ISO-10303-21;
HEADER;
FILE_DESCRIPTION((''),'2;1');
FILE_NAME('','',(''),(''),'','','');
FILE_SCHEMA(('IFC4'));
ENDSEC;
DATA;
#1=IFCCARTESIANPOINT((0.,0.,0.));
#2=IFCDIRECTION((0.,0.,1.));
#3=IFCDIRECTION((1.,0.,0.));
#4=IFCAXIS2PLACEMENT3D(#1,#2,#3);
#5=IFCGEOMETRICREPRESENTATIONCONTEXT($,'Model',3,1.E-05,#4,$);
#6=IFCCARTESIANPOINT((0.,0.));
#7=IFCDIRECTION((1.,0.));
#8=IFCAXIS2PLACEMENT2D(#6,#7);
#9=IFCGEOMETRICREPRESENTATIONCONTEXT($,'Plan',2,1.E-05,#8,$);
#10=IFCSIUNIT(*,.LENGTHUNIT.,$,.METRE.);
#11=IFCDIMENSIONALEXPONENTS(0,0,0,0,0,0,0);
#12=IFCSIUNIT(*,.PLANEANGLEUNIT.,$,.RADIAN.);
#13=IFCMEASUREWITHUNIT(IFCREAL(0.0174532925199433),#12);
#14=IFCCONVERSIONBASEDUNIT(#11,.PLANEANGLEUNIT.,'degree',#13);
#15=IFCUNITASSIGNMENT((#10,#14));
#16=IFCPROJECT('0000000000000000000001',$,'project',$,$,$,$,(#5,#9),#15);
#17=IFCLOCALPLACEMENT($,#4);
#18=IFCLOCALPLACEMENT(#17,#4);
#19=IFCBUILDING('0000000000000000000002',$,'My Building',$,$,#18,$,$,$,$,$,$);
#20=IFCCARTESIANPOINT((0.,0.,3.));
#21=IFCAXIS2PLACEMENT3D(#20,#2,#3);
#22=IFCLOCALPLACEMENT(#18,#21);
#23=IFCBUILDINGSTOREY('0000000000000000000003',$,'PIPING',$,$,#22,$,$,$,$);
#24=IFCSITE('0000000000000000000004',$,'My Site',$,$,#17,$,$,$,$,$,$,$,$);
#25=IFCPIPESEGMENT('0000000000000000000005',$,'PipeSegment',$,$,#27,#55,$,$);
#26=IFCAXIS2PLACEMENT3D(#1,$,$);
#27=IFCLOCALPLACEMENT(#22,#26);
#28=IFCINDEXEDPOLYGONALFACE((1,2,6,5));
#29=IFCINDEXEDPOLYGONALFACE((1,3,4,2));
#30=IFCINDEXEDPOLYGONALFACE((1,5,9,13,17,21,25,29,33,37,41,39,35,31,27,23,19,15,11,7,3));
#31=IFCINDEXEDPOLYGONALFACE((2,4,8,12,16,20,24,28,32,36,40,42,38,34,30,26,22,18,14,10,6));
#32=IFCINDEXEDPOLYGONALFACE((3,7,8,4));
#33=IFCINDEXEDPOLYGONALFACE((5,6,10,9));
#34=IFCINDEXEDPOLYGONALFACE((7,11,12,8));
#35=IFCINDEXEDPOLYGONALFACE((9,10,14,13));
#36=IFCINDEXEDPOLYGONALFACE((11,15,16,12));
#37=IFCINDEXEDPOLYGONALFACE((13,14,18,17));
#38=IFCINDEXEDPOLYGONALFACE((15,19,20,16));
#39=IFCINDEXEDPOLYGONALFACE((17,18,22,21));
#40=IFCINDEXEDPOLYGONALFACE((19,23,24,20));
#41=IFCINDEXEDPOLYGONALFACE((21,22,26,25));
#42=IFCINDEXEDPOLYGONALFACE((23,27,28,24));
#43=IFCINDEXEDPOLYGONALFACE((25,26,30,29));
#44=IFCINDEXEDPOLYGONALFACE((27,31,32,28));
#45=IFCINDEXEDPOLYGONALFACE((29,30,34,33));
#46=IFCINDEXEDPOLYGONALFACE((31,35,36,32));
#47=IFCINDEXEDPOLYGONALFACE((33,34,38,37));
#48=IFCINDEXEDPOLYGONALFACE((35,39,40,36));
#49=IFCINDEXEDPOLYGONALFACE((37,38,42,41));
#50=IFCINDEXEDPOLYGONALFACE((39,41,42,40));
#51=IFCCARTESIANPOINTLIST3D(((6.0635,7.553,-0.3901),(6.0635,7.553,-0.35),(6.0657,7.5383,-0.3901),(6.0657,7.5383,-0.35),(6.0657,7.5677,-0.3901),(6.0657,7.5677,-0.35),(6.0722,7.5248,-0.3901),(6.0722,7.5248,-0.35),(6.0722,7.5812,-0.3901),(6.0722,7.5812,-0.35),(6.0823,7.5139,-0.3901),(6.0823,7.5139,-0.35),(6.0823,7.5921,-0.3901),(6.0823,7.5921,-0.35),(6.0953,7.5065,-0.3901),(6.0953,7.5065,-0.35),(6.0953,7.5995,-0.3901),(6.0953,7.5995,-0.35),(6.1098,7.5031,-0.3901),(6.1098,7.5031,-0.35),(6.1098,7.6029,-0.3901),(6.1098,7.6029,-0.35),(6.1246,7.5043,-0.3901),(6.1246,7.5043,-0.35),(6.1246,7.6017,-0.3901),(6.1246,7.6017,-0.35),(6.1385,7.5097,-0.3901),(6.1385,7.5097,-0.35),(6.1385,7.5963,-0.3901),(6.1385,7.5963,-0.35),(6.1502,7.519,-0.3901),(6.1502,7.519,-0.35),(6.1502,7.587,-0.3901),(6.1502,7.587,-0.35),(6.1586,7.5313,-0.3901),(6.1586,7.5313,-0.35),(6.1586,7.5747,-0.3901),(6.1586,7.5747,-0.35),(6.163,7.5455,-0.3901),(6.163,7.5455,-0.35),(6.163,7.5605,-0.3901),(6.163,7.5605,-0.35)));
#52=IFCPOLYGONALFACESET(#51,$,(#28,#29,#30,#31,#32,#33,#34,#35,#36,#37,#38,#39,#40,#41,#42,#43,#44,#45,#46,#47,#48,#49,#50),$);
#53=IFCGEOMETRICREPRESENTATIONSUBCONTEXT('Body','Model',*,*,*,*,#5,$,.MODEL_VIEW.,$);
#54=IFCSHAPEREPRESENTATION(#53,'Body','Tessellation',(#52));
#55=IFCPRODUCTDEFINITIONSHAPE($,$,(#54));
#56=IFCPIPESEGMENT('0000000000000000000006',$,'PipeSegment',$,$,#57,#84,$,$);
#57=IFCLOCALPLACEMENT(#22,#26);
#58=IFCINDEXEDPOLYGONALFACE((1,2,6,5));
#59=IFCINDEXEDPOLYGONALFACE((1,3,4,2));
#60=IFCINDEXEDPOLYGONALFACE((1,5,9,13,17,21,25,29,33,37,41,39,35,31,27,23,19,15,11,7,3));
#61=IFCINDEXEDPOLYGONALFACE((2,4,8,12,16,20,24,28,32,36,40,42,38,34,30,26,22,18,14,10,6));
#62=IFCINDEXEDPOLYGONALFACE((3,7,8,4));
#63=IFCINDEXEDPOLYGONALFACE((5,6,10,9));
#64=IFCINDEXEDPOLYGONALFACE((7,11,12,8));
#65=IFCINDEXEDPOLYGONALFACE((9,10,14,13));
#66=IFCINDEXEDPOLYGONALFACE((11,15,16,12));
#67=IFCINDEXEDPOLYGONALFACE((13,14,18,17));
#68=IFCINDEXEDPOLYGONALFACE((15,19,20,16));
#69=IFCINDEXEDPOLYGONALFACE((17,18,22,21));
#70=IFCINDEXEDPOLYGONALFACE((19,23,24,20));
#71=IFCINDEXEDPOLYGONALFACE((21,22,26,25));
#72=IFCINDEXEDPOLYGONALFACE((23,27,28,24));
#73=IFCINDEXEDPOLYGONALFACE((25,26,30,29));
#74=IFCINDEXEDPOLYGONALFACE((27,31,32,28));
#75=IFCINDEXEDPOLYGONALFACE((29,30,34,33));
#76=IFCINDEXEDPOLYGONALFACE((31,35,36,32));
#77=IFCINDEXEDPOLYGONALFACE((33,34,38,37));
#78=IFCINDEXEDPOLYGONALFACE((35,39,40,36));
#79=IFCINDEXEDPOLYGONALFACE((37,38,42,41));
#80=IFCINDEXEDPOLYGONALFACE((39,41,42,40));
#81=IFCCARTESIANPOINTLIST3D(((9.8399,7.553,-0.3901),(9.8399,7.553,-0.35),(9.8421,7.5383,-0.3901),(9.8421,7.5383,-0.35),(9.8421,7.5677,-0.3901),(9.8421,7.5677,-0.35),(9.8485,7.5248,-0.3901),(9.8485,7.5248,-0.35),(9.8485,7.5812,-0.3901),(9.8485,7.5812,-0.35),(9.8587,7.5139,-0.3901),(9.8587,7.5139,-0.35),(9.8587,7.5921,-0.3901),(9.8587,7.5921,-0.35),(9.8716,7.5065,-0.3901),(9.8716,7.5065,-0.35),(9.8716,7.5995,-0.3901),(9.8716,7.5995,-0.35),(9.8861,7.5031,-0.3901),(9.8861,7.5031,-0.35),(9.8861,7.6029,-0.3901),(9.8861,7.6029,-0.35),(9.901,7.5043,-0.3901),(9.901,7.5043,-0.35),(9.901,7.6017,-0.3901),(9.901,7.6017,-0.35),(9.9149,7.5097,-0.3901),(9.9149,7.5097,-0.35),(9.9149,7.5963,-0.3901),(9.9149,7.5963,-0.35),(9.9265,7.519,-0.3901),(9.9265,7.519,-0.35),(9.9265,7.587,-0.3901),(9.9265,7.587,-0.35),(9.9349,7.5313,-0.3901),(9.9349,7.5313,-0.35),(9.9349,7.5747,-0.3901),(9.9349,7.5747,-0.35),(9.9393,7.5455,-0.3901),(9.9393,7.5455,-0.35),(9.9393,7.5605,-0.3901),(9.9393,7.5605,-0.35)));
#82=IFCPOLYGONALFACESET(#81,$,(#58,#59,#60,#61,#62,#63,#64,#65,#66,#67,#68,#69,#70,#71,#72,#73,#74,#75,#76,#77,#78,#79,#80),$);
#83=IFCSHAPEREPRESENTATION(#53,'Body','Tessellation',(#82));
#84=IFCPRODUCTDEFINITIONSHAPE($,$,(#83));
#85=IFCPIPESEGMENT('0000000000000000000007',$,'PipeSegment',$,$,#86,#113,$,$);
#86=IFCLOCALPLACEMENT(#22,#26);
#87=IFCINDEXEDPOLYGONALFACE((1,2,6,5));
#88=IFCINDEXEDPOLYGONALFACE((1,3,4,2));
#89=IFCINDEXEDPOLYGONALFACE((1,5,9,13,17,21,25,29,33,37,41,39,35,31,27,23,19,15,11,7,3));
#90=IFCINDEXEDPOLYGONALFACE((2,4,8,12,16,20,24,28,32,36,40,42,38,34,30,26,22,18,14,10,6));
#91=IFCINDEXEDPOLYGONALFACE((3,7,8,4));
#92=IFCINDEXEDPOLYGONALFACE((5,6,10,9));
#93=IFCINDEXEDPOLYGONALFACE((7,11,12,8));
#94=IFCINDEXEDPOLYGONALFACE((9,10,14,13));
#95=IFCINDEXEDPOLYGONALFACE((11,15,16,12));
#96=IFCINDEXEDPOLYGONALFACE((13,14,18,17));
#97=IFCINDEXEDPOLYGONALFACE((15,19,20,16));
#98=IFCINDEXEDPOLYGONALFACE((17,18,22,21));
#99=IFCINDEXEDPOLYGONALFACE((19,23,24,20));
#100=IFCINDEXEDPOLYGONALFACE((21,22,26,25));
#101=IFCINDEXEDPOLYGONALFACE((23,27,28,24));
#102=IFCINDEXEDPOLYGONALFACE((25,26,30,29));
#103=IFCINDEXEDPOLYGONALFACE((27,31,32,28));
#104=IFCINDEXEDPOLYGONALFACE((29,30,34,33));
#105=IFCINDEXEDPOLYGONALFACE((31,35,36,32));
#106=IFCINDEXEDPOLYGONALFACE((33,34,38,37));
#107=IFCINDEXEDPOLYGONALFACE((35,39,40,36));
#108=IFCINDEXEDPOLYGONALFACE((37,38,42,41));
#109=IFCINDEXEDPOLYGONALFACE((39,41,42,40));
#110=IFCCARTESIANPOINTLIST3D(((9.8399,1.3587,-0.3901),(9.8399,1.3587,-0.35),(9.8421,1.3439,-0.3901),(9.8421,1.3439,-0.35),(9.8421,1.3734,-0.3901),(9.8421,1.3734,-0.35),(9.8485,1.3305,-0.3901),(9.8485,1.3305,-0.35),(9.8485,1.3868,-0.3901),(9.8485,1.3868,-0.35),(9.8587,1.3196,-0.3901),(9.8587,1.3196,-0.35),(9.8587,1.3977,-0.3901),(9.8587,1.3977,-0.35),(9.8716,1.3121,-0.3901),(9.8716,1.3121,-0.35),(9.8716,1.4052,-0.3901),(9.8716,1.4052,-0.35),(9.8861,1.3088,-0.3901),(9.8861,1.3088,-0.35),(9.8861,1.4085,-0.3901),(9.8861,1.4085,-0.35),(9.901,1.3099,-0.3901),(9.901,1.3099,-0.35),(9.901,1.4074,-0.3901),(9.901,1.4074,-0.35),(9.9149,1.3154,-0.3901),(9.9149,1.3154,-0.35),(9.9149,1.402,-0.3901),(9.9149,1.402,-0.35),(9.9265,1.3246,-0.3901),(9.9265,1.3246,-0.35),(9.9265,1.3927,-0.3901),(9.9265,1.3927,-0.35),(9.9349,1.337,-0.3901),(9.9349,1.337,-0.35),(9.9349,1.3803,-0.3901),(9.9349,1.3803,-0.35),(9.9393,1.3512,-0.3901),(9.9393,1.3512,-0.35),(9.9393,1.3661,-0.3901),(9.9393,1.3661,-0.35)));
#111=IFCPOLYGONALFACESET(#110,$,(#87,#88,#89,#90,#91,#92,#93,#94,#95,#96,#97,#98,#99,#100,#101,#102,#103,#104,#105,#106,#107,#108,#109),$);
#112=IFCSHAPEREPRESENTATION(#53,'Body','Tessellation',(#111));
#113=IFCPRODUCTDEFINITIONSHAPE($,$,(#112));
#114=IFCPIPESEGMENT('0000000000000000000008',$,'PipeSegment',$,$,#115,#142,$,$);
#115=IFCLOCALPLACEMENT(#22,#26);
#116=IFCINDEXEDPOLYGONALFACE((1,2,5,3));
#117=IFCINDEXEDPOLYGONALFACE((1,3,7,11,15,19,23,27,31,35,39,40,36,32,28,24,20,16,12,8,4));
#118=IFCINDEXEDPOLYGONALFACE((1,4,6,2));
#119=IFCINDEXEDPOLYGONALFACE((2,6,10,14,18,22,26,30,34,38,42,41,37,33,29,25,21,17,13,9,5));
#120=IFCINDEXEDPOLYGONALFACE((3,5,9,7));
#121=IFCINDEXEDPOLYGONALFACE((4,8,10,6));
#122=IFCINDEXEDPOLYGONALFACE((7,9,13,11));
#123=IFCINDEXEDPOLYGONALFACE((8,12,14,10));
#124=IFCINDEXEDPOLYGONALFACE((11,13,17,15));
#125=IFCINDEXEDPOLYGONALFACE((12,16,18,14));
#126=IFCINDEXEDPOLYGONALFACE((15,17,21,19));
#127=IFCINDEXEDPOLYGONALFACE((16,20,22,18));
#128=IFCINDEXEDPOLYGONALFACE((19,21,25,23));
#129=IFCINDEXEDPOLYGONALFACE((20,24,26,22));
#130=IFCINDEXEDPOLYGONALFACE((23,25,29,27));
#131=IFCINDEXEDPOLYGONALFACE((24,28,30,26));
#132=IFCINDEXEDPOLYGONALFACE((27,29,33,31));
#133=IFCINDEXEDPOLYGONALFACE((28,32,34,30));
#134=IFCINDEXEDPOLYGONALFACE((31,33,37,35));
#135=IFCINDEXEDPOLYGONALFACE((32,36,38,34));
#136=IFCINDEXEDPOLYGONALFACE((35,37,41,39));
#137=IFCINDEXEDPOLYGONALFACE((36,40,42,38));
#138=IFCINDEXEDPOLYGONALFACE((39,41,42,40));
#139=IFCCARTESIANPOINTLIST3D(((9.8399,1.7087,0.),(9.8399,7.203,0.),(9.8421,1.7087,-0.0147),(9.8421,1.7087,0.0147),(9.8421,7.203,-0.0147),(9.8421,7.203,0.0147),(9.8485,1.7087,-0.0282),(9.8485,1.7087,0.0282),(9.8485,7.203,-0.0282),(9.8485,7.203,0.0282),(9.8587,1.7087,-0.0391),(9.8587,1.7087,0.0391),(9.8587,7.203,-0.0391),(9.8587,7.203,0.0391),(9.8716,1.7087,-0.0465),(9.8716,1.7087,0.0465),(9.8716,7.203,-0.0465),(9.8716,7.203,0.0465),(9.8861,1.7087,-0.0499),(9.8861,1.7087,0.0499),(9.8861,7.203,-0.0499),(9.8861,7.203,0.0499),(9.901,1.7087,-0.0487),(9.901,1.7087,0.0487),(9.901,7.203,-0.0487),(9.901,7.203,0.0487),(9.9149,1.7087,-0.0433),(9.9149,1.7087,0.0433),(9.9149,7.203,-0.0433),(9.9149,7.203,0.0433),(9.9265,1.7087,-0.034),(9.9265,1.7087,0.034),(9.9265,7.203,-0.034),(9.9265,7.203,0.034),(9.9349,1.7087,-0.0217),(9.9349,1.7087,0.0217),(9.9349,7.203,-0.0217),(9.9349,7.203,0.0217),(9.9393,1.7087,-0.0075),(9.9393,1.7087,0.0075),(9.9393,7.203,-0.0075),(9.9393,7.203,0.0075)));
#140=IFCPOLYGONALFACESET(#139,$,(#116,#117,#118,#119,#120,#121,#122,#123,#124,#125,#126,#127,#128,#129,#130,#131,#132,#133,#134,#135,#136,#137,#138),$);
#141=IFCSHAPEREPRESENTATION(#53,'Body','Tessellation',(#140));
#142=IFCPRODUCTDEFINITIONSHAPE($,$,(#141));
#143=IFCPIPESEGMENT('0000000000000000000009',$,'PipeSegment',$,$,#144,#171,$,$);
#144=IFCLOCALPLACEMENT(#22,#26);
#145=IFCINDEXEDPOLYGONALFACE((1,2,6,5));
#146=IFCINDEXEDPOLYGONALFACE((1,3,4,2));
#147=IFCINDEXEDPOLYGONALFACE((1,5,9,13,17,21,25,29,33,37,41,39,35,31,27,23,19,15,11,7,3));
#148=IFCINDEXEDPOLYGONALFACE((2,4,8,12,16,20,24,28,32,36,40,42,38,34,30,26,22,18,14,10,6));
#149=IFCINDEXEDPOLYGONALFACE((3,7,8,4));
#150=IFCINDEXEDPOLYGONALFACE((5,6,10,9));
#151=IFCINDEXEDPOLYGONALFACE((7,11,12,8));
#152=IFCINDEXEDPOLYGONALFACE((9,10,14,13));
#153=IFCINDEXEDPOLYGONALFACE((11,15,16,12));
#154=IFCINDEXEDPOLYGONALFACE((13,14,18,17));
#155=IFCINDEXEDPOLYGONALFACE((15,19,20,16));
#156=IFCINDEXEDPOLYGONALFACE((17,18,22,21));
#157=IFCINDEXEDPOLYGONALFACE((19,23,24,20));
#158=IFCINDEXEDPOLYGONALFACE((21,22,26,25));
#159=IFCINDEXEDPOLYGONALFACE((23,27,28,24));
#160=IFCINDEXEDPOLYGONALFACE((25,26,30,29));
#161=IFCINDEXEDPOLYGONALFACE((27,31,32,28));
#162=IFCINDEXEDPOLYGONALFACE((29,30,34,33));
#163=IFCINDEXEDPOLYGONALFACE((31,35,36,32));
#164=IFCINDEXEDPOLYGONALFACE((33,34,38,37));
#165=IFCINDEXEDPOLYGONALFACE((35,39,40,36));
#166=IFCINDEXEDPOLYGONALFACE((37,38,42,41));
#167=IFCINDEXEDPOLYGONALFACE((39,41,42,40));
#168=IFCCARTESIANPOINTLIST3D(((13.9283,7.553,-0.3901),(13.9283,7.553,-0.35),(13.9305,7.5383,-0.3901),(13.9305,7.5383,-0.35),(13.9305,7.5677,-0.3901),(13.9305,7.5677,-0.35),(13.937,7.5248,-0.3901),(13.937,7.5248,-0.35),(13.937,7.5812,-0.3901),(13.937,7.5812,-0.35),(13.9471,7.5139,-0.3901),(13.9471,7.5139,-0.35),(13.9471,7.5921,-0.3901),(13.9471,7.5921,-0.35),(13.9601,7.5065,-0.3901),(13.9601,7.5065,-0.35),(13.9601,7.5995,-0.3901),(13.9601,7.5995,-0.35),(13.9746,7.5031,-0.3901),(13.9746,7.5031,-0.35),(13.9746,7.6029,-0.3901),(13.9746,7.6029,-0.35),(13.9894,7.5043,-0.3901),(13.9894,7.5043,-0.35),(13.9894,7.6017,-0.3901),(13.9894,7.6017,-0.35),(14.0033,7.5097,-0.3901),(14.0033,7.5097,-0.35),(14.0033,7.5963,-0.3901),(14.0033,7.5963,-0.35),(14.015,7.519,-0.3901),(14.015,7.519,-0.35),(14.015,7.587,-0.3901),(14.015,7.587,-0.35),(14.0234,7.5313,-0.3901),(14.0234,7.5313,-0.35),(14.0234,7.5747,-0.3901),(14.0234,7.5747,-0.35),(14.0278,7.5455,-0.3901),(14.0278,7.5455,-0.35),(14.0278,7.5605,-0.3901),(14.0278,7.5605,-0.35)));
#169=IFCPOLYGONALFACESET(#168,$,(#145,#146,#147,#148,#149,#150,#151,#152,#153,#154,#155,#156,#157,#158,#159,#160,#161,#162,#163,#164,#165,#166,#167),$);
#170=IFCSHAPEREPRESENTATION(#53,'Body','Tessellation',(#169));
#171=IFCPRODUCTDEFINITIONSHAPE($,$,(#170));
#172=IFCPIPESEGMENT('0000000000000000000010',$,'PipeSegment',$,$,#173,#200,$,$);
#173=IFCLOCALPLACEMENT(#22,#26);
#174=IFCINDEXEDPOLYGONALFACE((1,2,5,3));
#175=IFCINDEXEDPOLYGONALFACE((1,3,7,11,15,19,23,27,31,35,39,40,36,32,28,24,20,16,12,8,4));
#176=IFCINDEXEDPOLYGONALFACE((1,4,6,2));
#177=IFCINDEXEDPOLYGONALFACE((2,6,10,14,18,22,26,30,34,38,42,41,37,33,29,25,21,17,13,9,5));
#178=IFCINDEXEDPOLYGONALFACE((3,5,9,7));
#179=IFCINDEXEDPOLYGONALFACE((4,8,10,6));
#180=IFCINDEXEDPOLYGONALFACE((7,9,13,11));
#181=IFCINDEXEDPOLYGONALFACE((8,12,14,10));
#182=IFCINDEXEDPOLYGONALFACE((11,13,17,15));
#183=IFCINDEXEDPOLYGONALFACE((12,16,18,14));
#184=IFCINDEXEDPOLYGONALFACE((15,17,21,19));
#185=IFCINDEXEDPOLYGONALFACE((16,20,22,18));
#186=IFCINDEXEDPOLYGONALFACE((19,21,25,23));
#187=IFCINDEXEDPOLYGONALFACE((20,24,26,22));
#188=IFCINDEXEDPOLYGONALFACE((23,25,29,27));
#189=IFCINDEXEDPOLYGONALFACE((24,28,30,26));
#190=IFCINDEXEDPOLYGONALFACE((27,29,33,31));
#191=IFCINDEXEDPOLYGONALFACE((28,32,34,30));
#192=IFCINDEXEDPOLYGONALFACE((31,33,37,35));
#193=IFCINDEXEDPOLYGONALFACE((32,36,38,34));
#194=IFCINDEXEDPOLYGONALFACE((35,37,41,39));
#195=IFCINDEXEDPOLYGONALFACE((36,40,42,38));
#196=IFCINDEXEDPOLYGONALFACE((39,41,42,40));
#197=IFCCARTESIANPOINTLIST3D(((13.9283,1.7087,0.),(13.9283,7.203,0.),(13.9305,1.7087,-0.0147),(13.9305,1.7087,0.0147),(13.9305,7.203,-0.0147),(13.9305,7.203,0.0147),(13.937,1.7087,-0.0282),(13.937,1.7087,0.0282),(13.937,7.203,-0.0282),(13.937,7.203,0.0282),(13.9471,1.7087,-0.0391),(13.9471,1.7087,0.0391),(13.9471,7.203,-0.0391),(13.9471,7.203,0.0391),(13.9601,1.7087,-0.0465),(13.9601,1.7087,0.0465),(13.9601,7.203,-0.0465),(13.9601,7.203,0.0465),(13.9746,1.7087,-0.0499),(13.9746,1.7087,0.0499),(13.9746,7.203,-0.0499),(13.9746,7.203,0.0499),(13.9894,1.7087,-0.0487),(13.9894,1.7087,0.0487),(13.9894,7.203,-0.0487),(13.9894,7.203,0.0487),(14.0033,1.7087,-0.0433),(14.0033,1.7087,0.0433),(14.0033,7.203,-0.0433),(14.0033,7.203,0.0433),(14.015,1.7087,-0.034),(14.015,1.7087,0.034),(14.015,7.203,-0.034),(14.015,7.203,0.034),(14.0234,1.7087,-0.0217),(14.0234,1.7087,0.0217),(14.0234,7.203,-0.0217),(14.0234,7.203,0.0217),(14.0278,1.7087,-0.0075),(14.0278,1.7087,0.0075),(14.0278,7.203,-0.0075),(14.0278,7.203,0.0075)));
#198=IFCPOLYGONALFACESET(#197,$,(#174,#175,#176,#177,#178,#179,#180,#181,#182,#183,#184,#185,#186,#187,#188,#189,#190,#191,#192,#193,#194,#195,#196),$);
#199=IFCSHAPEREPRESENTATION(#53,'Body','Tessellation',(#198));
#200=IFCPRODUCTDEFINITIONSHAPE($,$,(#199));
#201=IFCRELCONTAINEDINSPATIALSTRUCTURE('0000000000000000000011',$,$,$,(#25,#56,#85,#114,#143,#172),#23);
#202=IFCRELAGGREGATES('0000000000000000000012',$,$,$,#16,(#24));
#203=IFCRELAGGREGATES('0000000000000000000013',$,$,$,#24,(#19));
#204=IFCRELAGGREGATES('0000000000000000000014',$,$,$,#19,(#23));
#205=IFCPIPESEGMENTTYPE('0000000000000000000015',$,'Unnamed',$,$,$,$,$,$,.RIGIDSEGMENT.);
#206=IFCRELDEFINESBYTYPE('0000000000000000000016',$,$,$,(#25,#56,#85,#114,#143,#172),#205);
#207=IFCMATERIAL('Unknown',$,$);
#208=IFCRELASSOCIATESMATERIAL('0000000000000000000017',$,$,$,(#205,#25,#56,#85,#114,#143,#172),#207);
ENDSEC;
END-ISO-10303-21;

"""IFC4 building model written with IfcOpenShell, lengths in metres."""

from ifc_helpers import new_model, entity, si_unit, converted_unit, frame, origin_with_axes, origin_2d_with_axis, place, context, subcontext, project, spatial, circle, extrude, material, material_profile, profile_set, profile_usage, type_object, element, save


model = new_model("IFC4")

# Units and contexts
model_context = context("Model", 3, precision=1e-05, world=origin_with_axes())
plan_context = context("Plan", 2, precision=1e-05, world=origin_2d_with_axis())
body_context = subcontext(model_context, "Body", "Model", "MODEL_VIEW")
ifc_project = project(units=[si_unit("LENGTHUNIT", "METRE"), converted_unit("PLANEANGLEUNIT", "degree", entity("IfcReal", 0.0174532925199433), si_unit("PLANEANGLEUNIT", "RADIAN"), dimensions=[0, 0, 0, 0, 0, 0, 0])], contexts=[model_context, plan_context])

# Site, building, storey
site_placement = place(None, origin_with_axes())
site = spatial("IfcSite", under=ifc_project, at=site_placement, Name="My Site")
building_placement = place(site_placement, origin_with_axes())
building = spatial("IfcBuilding", under=site, at=building_placement, Name="My Building")
storey_placement = place(building_placement, frame((0.0, 0.0, 3.0), z_axis=(0.0, 0.0, 1.0), x_axis=(1.0, 0.0, 0.0)))
storey = spatial("IfcBuildingStorey", under=building, at=storey_placement, Name="PIPING")

# Pipe segments
ifc_material = material(Name="Unknown")
ifc_material_profile = material_profile(ifc_material, circle(Radius=0.05))
ifc_profile_set = profile_set([ifc_material_profile])
pipe_segment_type = type_object("IfcPipeSegmentType", Name="Unnamed", PredefinedType="RIGIDSEGMENT", material=ifc_profile_set)
ifc_profile_usage_1 = profile_usage(ifc_profile_set, cardinal=5)
pipe_segment_1_placement = place(storey_placement, frame((6.1135, 7.553, -0.35), z_axis=(0.0, 0.0, -1.0), x_axis=(-1.0, 0.0, 0.0)))
element("IfcPipeSegment", 1, at=pipe_segment_1_placement, inside=storey, type_object=pipe_segment_type, material=ifc_profile_usage_1, Name="PipeSegment", context=body_context, shape_type="SweptSolid", body=[
    extrude(circle(Radius=0.05), origin_with_axes(), (0.0, 0.0, 1.0), 0.0401),
])
ifc_profile_usage_2 = profile_usage(ifc_profile_set, cardinal=5)
pipe_segment_2_placement = place(storey_placement, frame((9.8899, 7.553, -0.35), z_axis=(0.0, 0.0, -1.0), x_axis=(-1.0, 0.0, 0.0)))
element("IfcPipeSegment", 2, at=pipe_segment_2_placement, inside=storey, type_object=pipe_segment_type, material=ifc_profile_usage_2, Name="PipeSegment", context=body_context, shape_type="SweptSolid", body=[
    extrude(circle(Radius=0.05), origin_with_axes(), (0.0, 0.0, 1.0), 0.0401),
])
ifc_profile_usage_3 = profile_usage(ifc_profile_set, cardinal=5)
pipe_segment_3_placement = place(storey_placement, frame((9.8899, 1.3587, -0.35), z_axis=(0.0, 0.0, -1.0), x_axis=(-1.0, 0.0, 0.0)))
element("IfcPipeSegment", 3, at=pipe_segment_3_placement, inside=storey, type_object=pipe_segment_type, material=ifc_profile_usage_3, Name="PipeSegment", context=body_context, shape_type="SweptSolid", body=[
    extrude(circle(Radius=0.05), origin_with_axes(), (0.0, 0.0, 1.0), 0.0401),
])
ifc_profile_usage_4 = profile_usage(ifc_profile_set, cardinal=5)
pipe_segment_4_placement = place(storey_placement, frame((9.8899, 1.7087, 0.0), z_axis=(0.0, 1.0, 0.0), x_axis=(-1.0, 0.0, 0.0)))
element("IfcPipeSegment", 4, at=pipe_segment_4_placement, inside=storey, type_object=pipe_segment_type, material=ifc_profile_usage_4, Name="PipeSegment", context=body_context, shape_type="SweptSolid", body=[
    extrude(circle(Radius=0.05), origin_with_axes(), (0.0, 0.0, 1.0), 5.4943),
])
ifc_profile_usage_5 = profile_usage(ifc_profile_set, cardinal=5)
pipe_segment_5_placement = place(storey_placement, frame((13.9783, 7.553, -0.35), z_axis=(0.0, 0.0, -1.0), x_axis=(-1.0, 0.0, 0.0)))
element("IfcPipeSegment", 5, at=pipe_segment_5_placement, inside=storey, type_object=pipe_segment_type, material=ifc_profile_usage_5, Name="PipeSegment", context=body_context, shape_type="SweptSolid", body=[
    extrude(circle(Radius=0.05), origin_with_axes(), (0.0, 0.0, 1.0), 0.0401),
])
ifc_profile_usage_6 = profile_usage(ifc_profile_set, cardinal=5)
pipe_segment_6_placement = place(storey_placement, frame((13.9783, 1.7087, 0.0), z_axis=(0.0, 1.0, 0.0), x_axis=(-1.0, 0.0, 0.0)))
element("IfcPipeSegment", 6, at=pipe_segment_6_placement, inside=storey, type_object=pipe_segment_type, material=ifc_profile_usage_6, Name="PipeSegment", context=body_context, shape_type="SweptSolid", body=[
    extrude(circle(Radius=0.05), origin_with_axes(), (0.0, 0.0, 1.0), 5.4943),
])

save(model, "model.ifc")
